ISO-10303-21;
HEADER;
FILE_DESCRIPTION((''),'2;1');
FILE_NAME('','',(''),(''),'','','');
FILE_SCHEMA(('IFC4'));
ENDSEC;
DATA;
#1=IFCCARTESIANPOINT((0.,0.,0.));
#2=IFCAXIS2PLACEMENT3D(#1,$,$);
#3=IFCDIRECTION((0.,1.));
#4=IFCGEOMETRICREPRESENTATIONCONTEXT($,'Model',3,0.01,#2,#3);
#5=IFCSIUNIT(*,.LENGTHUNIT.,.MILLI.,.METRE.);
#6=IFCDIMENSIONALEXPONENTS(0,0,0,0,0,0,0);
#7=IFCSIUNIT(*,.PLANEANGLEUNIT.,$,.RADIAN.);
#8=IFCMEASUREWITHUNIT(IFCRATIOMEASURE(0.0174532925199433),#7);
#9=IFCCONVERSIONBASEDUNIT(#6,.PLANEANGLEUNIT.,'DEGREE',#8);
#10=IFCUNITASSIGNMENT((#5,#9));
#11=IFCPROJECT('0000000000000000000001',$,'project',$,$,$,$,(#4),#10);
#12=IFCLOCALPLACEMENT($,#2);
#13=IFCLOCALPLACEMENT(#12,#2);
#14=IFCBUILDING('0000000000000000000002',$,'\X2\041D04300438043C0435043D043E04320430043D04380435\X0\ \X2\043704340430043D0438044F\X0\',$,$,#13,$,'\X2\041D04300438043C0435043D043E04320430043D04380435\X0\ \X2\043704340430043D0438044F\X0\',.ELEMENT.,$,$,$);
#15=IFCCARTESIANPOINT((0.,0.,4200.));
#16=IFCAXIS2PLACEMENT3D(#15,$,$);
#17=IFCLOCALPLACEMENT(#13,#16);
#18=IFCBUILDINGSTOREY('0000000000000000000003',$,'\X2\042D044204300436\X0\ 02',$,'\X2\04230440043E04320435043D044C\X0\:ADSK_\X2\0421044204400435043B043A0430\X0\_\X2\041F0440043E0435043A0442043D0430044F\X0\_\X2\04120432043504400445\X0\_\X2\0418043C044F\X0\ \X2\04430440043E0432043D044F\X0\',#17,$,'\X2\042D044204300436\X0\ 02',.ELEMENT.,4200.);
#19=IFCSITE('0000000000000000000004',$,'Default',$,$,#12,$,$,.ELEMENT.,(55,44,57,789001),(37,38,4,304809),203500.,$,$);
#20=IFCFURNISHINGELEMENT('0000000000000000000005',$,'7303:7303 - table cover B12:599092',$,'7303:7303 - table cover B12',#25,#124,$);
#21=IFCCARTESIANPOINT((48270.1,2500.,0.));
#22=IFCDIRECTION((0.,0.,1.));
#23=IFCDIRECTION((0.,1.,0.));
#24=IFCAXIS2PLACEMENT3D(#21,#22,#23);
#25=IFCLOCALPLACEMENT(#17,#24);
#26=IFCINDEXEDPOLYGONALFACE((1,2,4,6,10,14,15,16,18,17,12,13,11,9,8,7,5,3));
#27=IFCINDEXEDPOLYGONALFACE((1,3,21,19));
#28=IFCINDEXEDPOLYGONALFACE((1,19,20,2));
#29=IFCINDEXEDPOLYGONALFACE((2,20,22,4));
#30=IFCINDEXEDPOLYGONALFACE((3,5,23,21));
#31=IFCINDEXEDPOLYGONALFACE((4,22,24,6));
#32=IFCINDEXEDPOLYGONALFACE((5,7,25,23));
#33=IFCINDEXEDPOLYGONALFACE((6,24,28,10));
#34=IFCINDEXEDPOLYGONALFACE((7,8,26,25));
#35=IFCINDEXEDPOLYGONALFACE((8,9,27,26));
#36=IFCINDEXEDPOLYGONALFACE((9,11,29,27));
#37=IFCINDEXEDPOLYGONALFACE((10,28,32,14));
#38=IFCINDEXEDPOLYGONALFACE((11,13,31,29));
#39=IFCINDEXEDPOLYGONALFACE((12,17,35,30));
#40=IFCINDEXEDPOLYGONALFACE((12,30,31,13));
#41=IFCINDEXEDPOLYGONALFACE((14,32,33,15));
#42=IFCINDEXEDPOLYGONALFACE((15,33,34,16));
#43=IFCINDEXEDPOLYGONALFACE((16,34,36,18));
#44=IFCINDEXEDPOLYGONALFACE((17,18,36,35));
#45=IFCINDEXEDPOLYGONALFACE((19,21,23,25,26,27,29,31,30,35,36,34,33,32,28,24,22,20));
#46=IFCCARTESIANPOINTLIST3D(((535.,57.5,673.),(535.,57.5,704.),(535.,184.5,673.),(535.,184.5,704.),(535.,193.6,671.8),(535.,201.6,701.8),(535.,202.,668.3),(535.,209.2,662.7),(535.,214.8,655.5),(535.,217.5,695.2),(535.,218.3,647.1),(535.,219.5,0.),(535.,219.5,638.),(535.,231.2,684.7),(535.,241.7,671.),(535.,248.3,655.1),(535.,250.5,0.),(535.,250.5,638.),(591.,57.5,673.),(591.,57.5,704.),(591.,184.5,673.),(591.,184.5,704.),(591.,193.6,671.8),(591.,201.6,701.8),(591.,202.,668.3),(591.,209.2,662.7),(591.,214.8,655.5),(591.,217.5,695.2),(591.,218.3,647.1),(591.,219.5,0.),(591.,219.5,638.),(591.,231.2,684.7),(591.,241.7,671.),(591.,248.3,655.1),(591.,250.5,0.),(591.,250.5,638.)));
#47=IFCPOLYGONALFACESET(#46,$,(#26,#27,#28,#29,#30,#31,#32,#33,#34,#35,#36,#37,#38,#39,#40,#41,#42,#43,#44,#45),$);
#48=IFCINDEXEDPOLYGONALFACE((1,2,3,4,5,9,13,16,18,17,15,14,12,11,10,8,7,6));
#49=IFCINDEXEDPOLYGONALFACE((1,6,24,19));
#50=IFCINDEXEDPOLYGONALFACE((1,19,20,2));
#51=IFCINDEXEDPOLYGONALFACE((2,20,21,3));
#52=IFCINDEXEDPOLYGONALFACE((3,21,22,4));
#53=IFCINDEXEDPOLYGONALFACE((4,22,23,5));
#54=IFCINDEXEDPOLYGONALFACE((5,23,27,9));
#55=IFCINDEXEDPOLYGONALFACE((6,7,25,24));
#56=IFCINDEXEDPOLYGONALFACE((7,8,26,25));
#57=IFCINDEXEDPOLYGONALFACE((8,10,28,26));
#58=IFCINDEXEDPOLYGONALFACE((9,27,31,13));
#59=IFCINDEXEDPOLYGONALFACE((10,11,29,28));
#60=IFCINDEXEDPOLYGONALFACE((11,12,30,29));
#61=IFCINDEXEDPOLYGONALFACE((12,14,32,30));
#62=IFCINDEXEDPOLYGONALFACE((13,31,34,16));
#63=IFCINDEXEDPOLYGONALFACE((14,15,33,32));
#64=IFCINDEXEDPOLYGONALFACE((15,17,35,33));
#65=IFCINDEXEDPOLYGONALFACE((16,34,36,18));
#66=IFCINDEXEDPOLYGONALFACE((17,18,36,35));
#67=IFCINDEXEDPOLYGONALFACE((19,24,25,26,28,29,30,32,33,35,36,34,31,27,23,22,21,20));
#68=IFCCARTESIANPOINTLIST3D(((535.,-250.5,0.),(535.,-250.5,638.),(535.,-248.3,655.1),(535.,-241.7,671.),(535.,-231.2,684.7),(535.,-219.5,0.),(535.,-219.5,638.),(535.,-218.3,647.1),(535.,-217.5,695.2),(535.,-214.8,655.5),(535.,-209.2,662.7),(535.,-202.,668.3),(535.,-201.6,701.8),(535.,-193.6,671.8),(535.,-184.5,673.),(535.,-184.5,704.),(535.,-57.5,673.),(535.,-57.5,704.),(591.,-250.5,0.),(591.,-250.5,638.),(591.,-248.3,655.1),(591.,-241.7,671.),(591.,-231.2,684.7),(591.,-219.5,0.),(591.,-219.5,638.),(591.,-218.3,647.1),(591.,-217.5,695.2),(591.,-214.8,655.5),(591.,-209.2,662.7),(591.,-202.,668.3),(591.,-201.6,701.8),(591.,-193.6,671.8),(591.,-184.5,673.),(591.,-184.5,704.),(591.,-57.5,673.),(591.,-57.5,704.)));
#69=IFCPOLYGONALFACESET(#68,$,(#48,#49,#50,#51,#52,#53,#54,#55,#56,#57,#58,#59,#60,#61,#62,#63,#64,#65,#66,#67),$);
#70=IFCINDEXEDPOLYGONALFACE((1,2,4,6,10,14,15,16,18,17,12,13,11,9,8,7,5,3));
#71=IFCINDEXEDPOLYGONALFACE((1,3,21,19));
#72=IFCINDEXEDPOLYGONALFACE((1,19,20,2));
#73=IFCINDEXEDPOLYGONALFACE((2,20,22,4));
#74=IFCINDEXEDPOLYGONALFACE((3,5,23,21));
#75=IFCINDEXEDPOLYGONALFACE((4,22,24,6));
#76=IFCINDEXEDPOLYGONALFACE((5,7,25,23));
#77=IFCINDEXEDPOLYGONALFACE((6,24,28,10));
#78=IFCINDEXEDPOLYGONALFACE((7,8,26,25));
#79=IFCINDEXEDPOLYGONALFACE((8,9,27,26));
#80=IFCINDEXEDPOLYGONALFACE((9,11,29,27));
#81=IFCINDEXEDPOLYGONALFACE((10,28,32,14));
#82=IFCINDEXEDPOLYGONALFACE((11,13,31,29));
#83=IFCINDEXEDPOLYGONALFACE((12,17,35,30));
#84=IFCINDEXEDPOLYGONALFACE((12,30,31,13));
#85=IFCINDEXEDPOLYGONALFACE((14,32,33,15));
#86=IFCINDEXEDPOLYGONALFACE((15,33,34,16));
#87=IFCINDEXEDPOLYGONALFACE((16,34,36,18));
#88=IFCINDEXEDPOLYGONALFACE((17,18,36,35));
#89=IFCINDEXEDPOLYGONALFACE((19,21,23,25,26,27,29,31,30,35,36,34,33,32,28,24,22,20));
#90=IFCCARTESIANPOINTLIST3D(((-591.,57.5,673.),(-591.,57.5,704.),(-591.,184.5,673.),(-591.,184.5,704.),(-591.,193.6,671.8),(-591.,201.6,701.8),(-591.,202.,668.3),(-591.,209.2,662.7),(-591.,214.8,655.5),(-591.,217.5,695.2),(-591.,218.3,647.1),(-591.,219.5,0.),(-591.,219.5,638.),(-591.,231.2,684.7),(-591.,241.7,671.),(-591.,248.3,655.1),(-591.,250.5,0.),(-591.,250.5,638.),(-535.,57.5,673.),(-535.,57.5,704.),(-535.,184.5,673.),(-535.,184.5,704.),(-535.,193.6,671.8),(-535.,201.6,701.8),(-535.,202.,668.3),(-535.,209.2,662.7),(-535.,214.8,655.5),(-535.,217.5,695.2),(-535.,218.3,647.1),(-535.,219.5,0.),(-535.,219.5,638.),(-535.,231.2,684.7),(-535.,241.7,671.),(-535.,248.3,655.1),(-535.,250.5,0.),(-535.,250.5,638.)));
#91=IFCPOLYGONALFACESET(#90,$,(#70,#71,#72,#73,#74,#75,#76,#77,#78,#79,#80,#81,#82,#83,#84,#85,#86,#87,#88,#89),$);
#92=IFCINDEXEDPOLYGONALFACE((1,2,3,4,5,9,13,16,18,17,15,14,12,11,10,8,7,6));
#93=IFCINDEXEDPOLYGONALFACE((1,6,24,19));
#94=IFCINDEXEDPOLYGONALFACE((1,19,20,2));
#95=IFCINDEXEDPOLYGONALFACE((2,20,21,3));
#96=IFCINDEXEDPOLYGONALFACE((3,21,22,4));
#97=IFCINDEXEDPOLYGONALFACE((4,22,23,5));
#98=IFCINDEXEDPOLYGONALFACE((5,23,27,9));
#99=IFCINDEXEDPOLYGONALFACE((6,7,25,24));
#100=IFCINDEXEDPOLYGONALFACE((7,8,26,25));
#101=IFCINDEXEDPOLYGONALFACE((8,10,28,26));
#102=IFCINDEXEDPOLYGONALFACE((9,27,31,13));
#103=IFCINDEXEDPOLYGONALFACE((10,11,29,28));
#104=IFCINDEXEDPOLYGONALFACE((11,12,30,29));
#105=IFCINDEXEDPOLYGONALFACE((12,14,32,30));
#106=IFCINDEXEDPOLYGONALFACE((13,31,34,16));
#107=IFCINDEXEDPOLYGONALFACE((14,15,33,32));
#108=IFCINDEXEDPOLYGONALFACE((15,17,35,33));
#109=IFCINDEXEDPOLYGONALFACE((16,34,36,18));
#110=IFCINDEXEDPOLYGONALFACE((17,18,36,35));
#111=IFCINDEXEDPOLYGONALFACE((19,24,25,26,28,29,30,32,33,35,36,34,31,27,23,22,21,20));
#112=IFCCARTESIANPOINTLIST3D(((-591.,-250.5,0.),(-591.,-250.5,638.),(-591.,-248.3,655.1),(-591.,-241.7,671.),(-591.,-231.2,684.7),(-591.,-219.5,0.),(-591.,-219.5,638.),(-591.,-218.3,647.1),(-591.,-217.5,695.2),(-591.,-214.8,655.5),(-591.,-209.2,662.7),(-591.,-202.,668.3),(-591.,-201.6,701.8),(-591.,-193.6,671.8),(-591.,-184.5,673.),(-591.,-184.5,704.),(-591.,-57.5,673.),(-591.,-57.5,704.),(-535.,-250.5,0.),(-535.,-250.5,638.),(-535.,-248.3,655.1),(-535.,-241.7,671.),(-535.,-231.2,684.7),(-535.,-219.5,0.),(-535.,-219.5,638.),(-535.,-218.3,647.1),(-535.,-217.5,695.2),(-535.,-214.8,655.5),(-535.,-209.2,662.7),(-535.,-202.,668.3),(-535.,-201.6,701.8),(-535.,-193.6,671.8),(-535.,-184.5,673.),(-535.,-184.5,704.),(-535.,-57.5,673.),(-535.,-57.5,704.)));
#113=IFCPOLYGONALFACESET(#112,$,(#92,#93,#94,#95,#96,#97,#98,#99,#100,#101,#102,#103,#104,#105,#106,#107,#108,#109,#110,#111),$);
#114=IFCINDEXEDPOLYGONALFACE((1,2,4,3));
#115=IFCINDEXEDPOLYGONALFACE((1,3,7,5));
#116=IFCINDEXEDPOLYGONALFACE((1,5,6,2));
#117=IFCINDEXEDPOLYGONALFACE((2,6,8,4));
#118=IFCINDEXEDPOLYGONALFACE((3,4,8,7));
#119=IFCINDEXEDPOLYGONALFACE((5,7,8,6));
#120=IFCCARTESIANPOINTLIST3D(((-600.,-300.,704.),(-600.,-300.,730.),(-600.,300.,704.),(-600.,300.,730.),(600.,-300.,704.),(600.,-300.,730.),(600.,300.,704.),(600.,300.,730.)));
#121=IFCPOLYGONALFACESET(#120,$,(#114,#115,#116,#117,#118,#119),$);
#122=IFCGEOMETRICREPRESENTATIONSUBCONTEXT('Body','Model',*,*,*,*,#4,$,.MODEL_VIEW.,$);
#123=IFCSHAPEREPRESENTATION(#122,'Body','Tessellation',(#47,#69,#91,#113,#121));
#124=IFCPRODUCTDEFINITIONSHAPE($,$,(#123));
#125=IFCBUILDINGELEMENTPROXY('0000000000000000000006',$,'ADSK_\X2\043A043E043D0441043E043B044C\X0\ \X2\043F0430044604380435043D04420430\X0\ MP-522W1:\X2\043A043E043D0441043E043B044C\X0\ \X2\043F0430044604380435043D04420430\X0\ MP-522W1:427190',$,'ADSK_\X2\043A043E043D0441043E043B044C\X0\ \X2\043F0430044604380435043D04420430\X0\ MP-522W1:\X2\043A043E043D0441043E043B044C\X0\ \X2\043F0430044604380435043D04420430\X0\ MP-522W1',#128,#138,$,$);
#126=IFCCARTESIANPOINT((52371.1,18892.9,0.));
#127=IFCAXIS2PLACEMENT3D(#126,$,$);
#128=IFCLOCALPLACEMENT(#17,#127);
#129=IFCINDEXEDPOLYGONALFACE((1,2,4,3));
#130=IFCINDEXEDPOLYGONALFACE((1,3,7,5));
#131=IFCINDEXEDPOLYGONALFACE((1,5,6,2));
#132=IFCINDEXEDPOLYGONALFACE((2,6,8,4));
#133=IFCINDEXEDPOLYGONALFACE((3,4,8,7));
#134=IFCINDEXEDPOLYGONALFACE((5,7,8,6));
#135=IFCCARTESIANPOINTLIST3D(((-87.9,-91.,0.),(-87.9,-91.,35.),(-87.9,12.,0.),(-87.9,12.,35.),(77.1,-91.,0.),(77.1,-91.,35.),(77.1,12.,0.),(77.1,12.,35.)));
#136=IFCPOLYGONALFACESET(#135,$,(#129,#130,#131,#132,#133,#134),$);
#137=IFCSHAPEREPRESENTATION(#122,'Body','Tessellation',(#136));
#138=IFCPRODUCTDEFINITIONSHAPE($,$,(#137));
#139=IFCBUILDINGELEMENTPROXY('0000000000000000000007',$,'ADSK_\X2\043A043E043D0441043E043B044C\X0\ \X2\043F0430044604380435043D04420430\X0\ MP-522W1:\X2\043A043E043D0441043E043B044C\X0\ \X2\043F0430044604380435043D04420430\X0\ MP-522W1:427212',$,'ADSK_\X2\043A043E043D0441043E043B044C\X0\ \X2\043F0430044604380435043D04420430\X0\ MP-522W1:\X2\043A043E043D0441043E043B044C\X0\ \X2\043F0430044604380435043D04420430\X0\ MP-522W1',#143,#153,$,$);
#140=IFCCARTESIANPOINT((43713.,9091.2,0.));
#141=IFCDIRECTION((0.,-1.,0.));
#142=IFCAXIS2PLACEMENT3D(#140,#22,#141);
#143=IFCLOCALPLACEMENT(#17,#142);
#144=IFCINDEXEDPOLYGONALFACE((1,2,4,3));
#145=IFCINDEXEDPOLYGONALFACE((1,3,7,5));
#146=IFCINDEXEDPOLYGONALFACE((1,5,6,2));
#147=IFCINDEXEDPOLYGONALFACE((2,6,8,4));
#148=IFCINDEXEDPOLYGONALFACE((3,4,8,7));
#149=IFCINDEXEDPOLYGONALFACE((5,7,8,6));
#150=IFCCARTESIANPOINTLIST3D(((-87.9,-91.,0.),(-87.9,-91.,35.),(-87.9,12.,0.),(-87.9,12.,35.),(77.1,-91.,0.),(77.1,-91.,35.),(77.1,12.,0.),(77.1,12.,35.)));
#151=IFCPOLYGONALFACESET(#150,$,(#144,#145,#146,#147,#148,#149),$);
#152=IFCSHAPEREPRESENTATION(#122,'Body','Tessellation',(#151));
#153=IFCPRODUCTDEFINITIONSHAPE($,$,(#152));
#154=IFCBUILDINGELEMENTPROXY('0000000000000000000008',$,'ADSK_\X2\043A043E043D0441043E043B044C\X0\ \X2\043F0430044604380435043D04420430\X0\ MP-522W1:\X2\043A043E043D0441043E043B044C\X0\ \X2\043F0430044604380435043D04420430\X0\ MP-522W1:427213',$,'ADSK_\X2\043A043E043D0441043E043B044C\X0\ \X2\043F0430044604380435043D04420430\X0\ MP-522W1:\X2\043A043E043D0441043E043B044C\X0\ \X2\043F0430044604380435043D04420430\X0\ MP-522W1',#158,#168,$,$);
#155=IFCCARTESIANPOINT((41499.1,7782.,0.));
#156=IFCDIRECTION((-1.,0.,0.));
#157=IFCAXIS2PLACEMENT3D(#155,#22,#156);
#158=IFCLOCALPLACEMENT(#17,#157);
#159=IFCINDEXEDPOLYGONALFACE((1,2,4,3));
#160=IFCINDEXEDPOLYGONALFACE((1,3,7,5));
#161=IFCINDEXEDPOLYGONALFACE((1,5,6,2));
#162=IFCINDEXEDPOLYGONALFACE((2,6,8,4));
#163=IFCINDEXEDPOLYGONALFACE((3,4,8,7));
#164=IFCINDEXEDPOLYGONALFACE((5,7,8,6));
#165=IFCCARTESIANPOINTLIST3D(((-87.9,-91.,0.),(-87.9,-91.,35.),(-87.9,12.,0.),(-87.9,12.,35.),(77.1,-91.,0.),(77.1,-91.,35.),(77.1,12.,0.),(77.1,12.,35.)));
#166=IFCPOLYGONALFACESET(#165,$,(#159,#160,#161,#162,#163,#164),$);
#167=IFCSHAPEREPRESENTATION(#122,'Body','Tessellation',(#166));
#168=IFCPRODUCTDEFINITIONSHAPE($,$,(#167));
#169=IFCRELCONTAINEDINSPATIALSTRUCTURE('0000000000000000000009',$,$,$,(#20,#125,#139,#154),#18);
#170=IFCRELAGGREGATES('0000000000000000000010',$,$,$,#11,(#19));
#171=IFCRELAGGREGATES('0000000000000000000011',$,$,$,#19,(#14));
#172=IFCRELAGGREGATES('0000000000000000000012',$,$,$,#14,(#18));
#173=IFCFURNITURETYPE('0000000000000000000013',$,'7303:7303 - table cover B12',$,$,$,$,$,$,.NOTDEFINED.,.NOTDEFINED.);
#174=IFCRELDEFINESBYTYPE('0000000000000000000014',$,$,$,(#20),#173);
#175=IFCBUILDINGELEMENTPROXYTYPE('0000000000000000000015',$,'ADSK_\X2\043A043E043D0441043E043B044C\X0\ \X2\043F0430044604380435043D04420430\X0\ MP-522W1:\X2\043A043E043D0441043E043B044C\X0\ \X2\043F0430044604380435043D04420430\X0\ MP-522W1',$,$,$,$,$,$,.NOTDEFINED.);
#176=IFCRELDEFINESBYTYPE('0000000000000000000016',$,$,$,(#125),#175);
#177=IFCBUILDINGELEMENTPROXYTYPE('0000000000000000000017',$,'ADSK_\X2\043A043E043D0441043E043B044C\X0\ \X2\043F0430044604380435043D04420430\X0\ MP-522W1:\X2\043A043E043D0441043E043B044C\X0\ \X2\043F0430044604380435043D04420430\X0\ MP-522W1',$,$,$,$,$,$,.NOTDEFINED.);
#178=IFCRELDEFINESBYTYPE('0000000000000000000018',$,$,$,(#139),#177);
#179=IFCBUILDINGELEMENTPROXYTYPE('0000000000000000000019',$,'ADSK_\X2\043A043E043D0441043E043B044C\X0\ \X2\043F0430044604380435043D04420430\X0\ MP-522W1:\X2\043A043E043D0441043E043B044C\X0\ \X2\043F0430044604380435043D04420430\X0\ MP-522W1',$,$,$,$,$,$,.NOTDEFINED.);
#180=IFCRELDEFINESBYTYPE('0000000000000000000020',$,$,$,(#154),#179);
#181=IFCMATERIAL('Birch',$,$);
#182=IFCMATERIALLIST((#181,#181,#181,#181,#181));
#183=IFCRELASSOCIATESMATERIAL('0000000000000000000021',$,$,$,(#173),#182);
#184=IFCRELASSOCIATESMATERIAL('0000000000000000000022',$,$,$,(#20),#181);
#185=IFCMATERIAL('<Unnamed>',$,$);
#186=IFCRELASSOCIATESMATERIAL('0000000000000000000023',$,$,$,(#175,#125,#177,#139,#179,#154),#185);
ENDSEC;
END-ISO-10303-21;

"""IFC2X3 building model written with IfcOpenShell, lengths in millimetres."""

from ifc_helpers import new_model, entity, si_unit, converted_unit, direction, frame, frame_2d, origin, origin_2d_with_axis, place, context, subcontext, project, spatial, polyline, circle_curve, parameter, trimmed, segment, composite_curve, rectangle, outline, extrude, source, transform, mapped, material, material_list, type_object, type_shapes, element, save


model = new_model("IFC2X3")

# Units and contexts
model_context = context("Model", 3, precision=0.01, world=origin(), true_north=direction((0.0, 1.0)))
body_context = subcontext(model_context, "Body", "Model", "MODEL_VIEW")
ifc_project = project(units=[si_unit("LENGTHUNIT", "METRE", prefix="MILLI"), converted_unit("PLANEANGLEUNIT", "DEGREE", entity("IfcRatioMeasure", 0.0174532925199433), si_unit("PLANEANGLEUNIT", "RADIAN"), dimensions=[0, 0, 0, 0, 0, 0, 0])], contexts=[model_context])

# Site, building, storey
site_placement = place(None, origin())
site = spatial("IfcSite", under=ifc_project, at=site_placement, Name="Default", CompositionType="ELEMENT", RefLatitude=(55, 44, 57, 789001), RefLongitude=(37, 38, 4, 304809), RefElevation=203500.0)
building_placement = place(site_placement, origin())
building = spatial("IfcBuilding", under=site, at=building_placement, Name="Наименование здания", LongName="Наименование здания", CompositionType="ELEMENT")
storey_placement = place(building_placement, frame((0.0, 0.0, 4200.0)))
storey = spatial("IfcBuildingStorey", under=building, at=storey_placement, Name="Этаж 02", ObjectType="Уровень:ADSK_Стрелка_Проектная_Вверх_Имя уровня", LongName="Этаж 02", CompositionType="ELEMENT", Elevation=4200.0)

# Furnishing element
ifc_material_1 = material(Name="Birch")
ifc_material_list_1 = material_list([ifc_material_1, ifc_material_1, ifc_material_1, ifc_material_1, ifc_material_1])
furniture_type = type_object("IfcFurnitureType", Name="7303:7303 - table cover B12", material=ifc_material_list_1)
shared_shape_1 = source(origin(), body_context, "Body", "SweptSolid", [
    extrude(outline(composite_curve([segment(polyline([(-200.2, -120.5), (-169.2, -120.5)]), True, "CONTINUOUS"), segment(polyline([(-169.2, -120.5), (-169.2, 6.5)]), True, "CONTINUOUS"), segment(trimmed(circle_curve(frame_2d((-134.2, 6.5), x_axis=(0.0, -1.0)), 35.0), [parameter(180.0)], [parameter(270.0)], True, "PARAMETER"), False, "CONTINUOUS"), segment(polyline([(-134.2, 41.5), (503.8, 41.5)]), True, "CONTINUOUS"), segment(polyline([(503.8, 41.5), (503.8, 72.5)]), True, "CONTINUOUS"), segment(polyline([(503.8, 72.5), (-134.2, 72.5)]), True, "CONTINUOUS"), segment(trimmed(circle_curve(frame_2d((-134.2, 6.5), x_axis=(0.0, -1.0)), 66.0), [parameter(180.0)], [parameter(270.0)], True, "PARAMETER"), True, "CONTINUOUS"), segment(polyline([(-200.2, 6.5), (-200.2, -120.5)]), True, "CONTINUOUS")], self_intersect=False)), frame((535.0, 178.0, 503.8), z_axis=(1.0, 0.0, 0.0), x_axis=(0.0, 0.0, -1.0)), (0.0, 0.0, 1.0), 56.0),
    extrude(outline(composite_curve([segment(polyline([(-120.5, -200.2), (6.5, -200.2)]), True, "CONTINUOUS"), segment(trimmed(circle_curve(frame_2d((6.5, -134.2), x_axis=(-1.0, 0.0)), 66.0), [parameter(90.0)], [parameter(180.0)], True, "PARAMETER"), True, "CONTINUOUS"), segment(polyline([(72.5, -134.2), (72.5, 503.8)]), True, "CONTINUOUS"), segment(polyline([(72.5, 503.8), (41.5, 503.8)]), True, "CONTINUOUS"), segment(polyline([(41.5, 503.8), (41.5, -134.2)]), True, "CONTINUOUS"), segment(trimmed(circle_curve(frame_2d((6.5, -134.2), x_axis=(-1.0, 0.0)), 35.0), [parameter(90.0)], [parameter(180.0)], True, "PARAMETER"), False, "CONTINUOUS"), segment(polyline([(6.5, -169.2), (-120.5, -169.2)]), True, "CONTINUOUS"), segment(polyline([(-120.5, -169.2), (-120.5, -200.2)]), True, "CONTINUOUS")], self_intersect=False)), frame((535.0, -178.0, 503.8), z_axis=(1.0, 0.0, 0.0), x_axis=(0.0, -1.0, 0.0)), (0.0, 0.0, 1.0), 56.0),
    extrude(outline(composite_curve([segment(polyline([(-200.2, -120.5), (-169.2, -120.5)]), True, "CONTINUOUS"), segment(polyline([(-169.2, -120.5), (-169.2, 6.5)]), True, "CONTINUOUS"), segment(trimmed(circle_curve(frame_2d((-134.2, 6.5), x_axis=(0.0, -1.0)), 35.0), [parameter(180.0)], [parameter(270.0)], True, "PARAMETER"), False, "CONTINUOUS"), segment(polyline([(-134.2, 41.5), (503.8, 41.5)]), True, "CONTINUOUS"), segment(polyline([(503.8, 41.5), (503.8, 72.5)]), True, "CONTINUOUS"), segment(polyline([(503.8, 72.5), (-134.2, 72.5)]), True, "CONTINUOUS"), segment(trimmed(circle_curve(frame_2d((-134.2, 6.5), x_axis=(0.0, -1.0)), 66.0), [parameter(180.0)], [parameter(270.0)], True, "PARAMETER"), True, "CONTINUOUS"), segment(polyline([(-200.2, 6.5), (-200.2, -120.5)]), True, "CONTINUOUS")], self_intersect=False)), frame((-591.0, 178.0, 503.8), z_axis=(1.0, 0.0, 0.0), x_axis=(0.0, 0.0, -1.0)), (0.0, 0.0, 1.0), 56.0),
    extrude(outline(composite_curve([segment(polyline([(-120.5, -200.2), (6.5, -200.2)]), True, "CONTINUOUS"), segment(trimmed(circle_curve(frame_2d((6.5, -134.2), x_axis=(-1.0, 0.0)), 66.0), [parameter(90.0)], [parameter(180.0)], True, "PARAMETER"), True, "CONTINUOUS"), segment(polyline([(72.5, -134.2), (72.5, 503.8)]), True, "CONTINUOUS"), segment(polyline([(72.5, 503.8), (41.5, 503.8)]), True, "CONTINUOUS"), segment(polyline([(41.5, 503.8), (41.5, -134.2)]), True, "CONTINUOUS"), segment(trimmed(circle_curve(frame_2d((6.5, -134.2), x_axis=(-1.0, 0.0)), 35.0), [parameter(90.0)], [parameter(180.0)], True, "PARAMETER"), False, "CONTINUOUS"), segment(polyline([(6.5, -169.2), (-120.5, -169.2)]), True, "CONTINUOUS"), segment(polyline([(-120.5, -169.2), (-120.5, -200.2)]), True, "CONTINUOUS")], self_intersect=False)), frame((-591.0, -178.0, 503.8), z_axis=(1.0, 0.0, 0.0), x_axis=(0.0, -1.0, 0.0)), (0.0, 0.0, 1.0), 56.0),
    extrude(rectangle(XDim=1200.0, YDim=600.0, at=origin_2d_with_axis()), frame((0.0, 0.0, 704.0), z_axis=(0.0, 0.0, 1.0), x_axis=(-1.0, 0.0, 0.0)), (0.0, 0.0, 1.0), 26.0),
])
type_shapes(furniture_type, [shared_shape_1])
furnishing_1_placement = place(storey_placement, frame((48270.1, 2500.0, 0.0), z_axis=(0.0, 0.0, 1.0), x_axis=(0.0, 1.0, 0.0)))
element("IfcFurnishingElement", 1, at=furnishing_1_placement, inside=storey, type_object=furniture_type, material=ifc_material_1, Name="7303:7303 - table cover B12:599092", ObjectType="7303:7303 - table cover B12", context=body_context, shape_type="MappedRepresentation", body=[
    mapped(shared_shape_1, transform((0.0, 0.0, 0.0), scale=1.0)),
])

# Building element proxies
ifc_material_2 = material(Name="<Unnamed>")
building_element_proxy_type_1 = type_object("IfcBuildingElementProxyType", Name="ADSK_консоль пациента MP-522W1:консоль пациента MP-522W1", PredefinedType="NOTDEFINED", material=ifc_material_2)
shared_shape_2 = source(origin(), body_context, "Body", "SweptSolid", [
    extrude(rectangle(XDim=165.0, YDim=103.0, at=origin_2d_with_axis()), frame((-5.4, -39.5, 0.0), z_axis=(0.0, 0.0, 1.0), x_axis=(-1.0, 0.0, 0.0)), (0.0, 0.0, 1.0), 35.0),
])
type_shapes(building_element_proxy_type_1, [shared_shape_2])
proxy_1_placement = place(storey_placement, frame((52371.1, 18892.9, 0.0)))
element("IfcBuildingElementProxy", 2, at=proxy_1_placement, inside=storey, type_object=building_element_proxy_type_1, material=ifc_material_2, Name="ADSK_консоль пациента MP-522W1:консоль пациента MP-522W1:427190", ObjectType="ADSK_консоль пациента MP-522W1:консоль пациента MP-522W1", context=body_context, shape_type="MappedRepresentation", body=[
    mapped(shared_shape_2, transform((0.0, 0.0, 0.0), scale=1.0)),
])
building_element_proxy_type_2 = type_object("IfcBuildingElementProxyType", Name="ADSK_консоль пациента MP-522W1:консоль пациента MP-522W1", PredefinedType="NOTDEFINED", material=ifc_material_2)
type_shapes(building_element_proxy_type_2, [shared_shape_2])
proxy_2_placement = place(storey_placement, frame((43713.0, 9091.2, 0.0), z_axis=(0.0, 0.0, 1.0), x_axis=(0.0, -1.0, 0.0)))
element("IfcBuildingElementProxy", 3, at=proxy_2_placement, inside=storey, type_object=building_element_proxy_type_2, material=ifc_material_2, Name="ADSK_консоль пациента MP-522W1:консоль пациента MP-522W1:427212", ObjectType="ADSK_консоль пациента MP-522W1:консоль пациента MP-522W1", context=body_context, shape_type="MappedRepresentation", body=[
    mapped(shared_shape_2, transform((0.0, 0.0, 0.0), scale=1.0)),
])
building_element_proxy_type_3 = type_object("IfcBuildingElementProxyType", Name="ADSK_консоль пациента MP-522W1:консоль пациента MP-522W1", PredefinedType="NOTDEFINED", material=ifc_material_2)
type_shapes(building_element_proxy_type_3, [shared_shape_2])
proxy_3_placement = place(storey_placement, frame((41499.1, 7782.0, 0.0), z_axis=(0.0, 0.0, 1.0), x_axis=(-1.0, 0.0, 0.0)))
element("IfcBuildingElementProxy", 4, at=proxy_3_placement, inside=storey, type_object=building_element_proxy_type_3, material=ifc_material_2, Name="ADSK_консоль пациента MP-522W1:консоль пациента MP-522W1:427213", ObjectType="ADSK_консоль пациента MP-522W1:консоль пациента MP-522W1", context=body_context, shape_type="MappedRepresentation", body=[
    mapped(shared_shape_2, transform((0.0, 0.0, 0.0), scale=1.0)),
])

save(model, "model.ifc")
